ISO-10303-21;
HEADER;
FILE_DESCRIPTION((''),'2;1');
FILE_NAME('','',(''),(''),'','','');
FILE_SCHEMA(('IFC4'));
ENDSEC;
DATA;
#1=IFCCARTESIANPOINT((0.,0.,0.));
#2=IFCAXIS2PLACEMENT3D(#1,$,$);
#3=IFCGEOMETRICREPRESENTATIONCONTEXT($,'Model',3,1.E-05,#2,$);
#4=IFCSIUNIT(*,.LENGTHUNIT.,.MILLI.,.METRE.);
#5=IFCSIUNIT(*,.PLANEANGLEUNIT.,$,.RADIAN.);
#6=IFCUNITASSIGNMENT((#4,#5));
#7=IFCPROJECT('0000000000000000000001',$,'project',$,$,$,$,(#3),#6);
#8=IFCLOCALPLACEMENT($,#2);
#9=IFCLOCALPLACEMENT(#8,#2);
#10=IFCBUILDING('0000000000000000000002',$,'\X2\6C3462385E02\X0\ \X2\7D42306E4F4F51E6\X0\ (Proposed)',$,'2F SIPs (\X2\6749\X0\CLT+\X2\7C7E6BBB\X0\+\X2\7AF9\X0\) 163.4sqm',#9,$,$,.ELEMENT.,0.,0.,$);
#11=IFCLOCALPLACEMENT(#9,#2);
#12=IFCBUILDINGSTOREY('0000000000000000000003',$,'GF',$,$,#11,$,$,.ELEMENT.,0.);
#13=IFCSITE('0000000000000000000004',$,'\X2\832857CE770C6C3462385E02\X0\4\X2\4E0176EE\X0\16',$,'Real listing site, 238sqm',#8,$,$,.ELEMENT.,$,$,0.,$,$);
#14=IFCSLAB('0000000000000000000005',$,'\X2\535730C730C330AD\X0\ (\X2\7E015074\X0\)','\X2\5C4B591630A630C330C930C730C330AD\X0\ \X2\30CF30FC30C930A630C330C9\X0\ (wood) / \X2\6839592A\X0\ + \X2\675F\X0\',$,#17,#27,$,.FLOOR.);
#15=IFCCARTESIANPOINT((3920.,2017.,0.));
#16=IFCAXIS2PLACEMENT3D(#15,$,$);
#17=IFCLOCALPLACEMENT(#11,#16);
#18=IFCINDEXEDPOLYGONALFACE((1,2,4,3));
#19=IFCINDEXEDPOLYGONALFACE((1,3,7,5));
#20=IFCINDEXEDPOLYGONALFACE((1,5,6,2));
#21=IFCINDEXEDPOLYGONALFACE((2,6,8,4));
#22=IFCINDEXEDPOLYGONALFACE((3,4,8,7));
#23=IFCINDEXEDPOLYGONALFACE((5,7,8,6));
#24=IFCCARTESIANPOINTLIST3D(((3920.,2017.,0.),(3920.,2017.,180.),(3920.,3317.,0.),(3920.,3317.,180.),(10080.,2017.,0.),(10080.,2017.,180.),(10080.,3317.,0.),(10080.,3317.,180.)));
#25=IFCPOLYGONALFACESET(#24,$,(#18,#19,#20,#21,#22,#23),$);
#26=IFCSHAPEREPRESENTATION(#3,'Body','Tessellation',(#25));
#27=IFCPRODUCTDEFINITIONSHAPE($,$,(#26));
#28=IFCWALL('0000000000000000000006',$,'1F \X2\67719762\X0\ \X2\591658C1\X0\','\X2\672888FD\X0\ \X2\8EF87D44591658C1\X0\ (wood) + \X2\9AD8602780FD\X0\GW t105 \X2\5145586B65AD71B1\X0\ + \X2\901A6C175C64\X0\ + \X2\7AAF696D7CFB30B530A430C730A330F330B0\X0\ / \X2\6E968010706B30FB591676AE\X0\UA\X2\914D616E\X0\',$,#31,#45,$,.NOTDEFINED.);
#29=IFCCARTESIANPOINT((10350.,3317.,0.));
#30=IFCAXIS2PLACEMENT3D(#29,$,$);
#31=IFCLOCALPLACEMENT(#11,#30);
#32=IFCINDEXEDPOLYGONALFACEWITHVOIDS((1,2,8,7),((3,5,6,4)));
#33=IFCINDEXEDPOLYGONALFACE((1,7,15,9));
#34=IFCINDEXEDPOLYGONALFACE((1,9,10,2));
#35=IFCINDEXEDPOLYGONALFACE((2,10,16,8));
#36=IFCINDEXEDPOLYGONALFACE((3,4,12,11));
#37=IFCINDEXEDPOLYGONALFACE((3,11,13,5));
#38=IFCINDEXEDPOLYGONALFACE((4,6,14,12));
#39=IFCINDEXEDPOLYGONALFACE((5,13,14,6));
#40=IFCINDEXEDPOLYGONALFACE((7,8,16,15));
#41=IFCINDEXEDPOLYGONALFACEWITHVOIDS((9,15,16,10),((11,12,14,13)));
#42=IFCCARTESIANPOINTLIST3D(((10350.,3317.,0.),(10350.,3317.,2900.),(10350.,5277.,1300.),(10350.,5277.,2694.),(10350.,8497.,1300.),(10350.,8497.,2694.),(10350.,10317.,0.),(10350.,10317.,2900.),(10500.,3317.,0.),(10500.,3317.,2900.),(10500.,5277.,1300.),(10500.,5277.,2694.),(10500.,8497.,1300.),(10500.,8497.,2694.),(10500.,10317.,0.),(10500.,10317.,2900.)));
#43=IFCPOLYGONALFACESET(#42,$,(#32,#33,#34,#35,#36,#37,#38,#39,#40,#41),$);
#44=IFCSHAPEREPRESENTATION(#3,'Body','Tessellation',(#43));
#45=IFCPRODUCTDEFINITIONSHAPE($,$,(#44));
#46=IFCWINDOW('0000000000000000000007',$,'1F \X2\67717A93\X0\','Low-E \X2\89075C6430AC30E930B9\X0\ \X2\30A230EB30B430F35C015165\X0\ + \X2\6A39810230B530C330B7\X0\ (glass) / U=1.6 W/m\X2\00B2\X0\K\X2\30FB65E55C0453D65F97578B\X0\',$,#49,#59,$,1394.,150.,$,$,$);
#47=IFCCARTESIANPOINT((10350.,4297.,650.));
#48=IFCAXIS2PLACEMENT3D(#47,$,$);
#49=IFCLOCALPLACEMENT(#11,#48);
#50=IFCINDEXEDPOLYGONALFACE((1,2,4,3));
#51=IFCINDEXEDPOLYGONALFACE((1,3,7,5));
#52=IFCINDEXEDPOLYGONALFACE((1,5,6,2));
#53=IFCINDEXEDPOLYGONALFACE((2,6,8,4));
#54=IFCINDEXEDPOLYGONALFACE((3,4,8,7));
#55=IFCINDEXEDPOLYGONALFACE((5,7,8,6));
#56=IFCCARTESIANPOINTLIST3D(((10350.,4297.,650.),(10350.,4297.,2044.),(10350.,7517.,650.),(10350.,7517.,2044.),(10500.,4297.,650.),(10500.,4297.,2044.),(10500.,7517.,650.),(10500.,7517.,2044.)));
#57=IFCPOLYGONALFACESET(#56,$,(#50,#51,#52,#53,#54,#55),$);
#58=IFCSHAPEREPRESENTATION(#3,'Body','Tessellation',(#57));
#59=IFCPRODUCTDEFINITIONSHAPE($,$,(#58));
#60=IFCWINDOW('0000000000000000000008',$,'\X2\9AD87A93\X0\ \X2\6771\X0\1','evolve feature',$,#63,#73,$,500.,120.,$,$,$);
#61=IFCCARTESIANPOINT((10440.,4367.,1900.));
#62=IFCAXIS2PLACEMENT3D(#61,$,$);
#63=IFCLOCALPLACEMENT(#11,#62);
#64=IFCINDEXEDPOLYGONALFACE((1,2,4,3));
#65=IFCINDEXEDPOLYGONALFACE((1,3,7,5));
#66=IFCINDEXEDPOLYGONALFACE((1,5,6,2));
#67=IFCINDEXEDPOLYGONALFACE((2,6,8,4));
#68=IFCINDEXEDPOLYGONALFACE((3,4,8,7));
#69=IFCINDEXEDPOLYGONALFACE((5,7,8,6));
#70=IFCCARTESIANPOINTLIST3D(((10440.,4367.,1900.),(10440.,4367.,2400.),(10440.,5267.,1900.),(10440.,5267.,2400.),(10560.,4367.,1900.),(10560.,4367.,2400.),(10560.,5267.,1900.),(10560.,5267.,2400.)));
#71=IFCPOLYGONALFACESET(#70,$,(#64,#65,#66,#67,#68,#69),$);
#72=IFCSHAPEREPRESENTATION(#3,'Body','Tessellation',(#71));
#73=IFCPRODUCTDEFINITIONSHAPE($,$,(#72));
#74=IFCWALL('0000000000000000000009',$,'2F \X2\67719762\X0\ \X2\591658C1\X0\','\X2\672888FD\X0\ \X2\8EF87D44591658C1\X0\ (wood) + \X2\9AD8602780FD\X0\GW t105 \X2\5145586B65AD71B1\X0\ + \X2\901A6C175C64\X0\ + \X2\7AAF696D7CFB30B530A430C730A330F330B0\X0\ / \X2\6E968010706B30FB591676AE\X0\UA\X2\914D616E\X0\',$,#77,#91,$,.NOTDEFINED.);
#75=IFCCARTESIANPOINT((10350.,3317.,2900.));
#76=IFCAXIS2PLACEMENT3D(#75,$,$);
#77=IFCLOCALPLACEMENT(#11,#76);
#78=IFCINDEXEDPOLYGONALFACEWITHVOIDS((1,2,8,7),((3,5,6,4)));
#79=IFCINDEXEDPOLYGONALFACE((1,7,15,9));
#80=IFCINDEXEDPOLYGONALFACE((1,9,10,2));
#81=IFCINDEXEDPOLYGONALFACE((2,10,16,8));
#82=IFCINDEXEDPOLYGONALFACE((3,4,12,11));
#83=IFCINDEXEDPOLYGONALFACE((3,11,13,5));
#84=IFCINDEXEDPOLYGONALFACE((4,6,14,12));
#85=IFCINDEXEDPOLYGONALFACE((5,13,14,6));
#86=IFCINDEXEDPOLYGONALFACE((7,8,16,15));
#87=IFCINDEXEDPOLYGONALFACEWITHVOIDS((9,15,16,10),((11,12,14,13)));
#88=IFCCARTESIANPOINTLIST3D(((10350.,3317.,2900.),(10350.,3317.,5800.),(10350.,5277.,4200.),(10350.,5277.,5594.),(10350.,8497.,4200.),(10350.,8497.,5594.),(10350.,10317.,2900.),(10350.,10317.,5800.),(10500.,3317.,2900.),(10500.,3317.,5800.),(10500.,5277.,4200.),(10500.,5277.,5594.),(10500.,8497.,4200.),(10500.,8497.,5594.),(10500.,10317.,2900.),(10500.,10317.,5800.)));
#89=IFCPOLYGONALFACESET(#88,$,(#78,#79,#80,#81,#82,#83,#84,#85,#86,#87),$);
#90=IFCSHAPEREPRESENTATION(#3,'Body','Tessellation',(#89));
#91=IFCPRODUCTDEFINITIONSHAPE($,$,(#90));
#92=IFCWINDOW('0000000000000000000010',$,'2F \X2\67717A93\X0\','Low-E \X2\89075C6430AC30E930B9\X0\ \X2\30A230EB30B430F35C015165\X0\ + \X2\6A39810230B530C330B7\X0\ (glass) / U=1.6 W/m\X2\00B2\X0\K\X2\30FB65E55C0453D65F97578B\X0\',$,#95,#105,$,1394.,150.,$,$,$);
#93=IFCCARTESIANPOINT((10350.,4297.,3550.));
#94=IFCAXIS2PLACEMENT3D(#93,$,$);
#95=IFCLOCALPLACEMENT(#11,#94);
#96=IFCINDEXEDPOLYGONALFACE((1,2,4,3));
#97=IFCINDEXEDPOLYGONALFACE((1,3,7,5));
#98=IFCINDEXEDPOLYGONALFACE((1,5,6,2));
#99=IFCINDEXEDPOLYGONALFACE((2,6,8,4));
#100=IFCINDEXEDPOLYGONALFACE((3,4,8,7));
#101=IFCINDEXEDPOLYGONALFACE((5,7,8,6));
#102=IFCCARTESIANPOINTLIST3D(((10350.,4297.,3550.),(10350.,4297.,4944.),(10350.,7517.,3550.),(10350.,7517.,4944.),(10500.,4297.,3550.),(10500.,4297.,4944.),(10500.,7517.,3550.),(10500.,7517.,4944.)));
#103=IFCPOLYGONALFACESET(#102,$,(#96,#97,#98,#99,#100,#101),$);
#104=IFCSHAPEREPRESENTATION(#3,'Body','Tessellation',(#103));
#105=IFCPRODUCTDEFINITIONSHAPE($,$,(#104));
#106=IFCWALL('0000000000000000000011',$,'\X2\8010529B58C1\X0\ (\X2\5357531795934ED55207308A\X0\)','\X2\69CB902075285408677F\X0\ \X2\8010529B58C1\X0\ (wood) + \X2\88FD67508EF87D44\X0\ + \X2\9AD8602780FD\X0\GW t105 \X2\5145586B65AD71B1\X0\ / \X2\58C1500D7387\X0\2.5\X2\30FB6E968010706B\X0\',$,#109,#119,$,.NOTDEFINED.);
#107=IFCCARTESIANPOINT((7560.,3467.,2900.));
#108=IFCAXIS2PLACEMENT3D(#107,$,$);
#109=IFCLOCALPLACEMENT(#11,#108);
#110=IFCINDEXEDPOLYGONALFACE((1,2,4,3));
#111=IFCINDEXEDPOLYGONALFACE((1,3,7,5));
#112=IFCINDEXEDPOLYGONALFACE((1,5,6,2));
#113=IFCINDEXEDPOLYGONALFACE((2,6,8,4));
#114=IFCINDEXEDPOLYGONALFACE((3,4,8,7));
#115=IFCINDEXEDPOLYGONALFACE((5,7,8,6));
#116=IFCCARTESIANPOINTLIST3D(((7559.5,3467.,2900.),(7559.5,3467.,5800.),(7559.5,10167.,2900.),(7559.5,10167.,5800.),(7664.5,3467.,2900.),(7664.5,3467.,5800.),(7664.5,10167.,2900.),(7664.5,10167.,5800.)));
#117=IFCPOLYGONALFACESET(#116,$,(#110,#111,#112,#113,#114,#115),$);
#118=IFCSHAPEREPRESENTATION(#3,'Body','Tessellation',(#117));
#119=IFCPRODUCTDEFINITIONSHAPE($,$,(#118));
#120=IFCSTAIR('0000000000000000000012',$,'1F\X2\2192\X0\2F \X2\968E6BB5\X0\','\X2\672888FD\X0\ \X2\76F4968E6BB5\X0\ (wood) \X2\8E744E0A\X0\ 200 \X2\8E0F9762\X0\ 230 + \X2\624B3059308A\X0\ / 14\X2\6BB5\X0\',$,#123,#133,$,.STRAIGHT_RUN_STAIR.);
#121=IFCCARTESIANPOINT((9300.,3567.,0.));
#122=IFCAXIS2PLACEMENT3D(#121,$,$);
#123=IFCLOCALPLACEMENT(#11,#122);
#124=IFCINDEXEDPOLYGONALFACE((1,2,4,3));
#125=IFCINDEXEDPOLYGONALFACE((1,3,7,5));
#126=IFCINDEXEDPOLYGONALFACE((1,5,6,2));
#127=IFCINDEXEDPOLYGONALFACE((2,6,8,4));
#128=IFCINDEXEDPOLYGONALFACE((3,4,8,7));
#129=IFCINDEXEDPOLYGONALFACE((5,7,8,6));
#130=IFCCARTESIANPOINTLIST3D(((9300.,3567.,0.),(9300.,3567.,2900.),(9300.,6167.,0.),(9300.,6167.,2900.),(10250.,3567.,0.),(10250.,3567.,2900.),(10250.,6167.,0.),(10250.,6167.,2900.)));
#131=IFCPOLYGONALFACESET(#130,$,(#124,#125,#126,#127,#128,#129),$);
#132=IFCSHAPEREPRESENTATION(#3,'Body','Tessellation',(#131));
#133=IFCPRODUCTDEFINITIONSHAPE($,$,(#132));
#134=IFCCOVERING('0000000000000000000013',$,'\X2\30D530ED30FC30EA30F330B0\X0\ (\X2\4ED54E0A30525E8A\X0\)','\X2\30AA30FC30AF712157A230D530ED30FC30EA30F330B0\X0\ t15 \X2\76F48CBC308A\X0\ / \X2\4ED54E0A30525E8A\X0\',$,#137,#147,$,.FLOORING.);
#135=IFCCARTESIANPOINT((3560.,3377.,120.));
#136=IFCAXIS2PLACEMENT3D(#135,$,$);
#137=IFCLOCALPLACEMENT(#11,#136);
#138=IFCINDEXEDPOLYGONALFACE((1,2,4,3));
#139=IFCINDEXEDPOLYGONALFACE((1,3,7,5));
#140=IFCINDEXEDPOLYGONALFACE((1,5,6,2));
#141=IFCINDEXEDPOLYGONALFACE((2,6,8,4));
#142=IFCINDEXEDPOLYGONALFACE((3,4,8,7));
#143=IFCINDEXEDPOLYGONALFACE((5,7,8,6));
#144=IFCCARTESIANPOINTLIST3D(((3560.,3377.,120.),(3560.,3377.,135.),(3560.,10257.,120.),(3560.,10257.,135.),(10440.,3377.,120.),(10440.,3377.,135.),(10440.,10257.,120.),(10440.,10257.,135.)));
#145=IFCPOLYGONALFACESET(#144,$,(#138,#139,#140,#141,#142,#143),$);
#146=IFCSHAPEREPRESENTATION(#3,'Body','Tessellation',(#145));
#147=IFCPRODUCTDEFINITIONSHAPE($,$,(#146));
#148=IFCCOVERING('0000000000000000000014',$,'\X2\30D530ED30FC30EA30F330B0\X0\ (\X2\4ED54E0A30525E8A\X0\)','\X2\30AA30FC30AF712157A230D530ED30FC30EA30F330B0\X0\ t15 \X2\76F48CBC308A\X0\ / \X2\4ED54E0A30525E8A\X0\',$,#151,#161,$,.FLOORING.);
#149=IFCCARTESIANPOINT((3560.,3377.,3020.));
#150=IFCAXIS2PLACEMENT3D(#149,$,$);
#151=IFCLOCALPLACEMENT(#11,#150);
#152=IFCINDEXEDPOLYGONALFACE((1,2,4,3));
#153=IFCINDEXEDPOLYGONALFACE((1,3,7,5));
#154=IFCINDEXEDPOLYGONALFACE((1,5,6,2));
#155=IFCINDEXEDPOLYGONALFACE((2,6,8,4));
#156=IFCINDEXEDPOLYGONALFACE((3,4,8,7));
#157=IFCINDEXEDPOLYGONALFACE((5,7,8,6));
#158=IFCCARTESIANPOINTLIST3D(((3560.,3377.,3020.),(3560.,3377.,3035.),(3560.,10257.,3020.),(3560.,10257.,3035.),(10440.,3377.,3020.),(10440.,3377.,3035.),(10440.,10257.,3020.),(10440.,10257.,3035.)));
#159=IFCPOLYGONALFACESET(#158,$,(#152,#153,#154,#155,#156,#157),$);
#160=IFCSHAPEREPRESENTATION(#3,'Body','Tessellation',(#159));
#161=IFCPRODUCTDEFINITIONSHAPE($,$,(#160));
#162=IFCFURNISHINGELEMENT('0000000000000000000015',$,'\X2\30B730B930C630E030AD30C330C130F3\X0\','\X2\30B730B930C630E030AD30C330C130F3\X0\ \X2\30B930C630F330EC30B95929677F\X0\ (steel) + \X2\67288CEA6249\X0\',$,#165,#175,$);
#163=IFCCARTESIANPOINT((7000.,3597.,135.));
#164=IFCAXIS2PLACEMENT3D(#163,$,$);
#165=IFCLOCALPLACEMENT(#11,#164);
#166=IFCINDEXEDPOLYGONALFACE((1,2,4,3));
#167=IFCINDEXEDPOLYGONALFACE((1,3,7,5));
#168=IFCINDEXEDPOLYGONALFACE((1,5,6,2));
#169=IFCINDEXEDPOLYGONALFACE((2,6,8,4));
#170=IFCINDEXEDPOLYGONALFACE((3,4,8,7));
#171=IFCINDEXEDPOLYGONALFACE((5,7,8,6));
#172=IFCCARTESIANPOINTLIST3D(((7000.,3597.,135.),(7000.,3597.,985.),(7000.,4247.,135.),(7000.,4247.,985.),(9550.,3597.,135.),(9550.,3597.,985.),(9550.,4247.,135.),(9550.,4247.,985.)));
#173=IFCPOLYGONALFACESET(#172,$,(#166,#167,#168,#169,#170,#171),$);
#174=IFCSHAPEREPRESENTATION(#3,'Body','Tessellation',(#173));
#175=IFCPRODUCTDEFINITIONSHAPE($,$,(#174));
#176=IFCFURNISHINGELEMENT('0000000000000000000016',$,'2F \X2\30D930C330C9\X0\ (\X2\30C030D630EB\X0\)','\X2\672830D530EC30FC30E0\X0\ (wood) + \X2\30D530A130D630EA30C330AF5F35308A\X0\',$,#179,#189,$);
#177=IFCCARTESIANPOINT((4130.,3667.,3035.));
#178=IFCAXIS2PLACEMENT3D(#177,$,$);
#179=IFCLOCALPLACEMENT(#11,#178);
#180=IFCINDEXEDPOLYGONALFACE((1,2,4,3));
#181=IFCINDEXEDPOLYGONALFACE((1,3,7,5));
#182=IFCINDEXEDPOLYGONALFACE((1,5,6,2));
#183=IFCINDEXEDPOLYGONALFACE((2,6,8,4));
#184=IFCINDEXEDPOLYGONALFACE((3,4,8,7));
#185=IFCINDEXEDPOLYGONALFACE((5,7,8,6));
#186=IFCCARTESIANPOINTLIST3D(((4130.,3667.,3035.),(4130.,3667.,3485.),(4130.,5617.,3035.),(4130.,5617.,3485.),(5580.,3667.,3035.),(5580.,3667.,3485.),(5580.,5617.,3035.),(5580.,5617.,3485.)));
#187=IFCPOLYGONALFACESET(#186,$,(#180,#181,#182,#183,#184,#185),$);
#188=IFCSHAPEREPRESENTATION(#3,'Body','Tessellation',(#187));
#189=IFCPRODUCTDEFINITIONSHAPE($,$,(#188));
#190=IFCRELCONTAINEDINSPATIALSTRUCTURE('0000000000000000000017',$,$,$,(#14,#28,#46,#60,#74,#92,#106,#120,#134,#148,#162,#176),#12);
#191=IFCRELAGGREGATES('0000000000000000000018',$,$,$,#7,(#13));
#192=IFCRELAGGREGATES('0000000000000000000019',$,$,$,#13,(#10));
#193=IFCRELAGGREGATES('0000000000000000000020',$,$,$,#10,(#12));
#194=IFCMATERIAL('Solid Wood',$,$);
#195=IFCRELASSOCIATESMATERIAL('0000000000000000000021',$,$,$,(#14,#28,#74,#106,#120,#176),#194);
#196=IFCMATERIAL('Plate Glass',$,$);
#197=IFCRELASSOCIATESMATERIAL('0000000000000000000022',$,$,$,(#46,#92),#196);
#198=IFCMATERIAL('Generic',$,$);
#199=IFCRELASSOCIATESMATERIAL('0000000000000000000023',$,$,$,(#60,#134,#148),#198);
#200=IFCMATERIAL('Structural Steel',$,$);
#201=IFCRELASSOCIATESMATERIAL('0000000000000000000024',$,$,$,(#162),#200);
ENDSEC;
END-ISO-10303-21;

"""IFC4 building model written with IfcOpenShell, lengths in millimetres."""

from ifc_helpers import new_model, si_unit, frame, frame_2d, origin, place, context, project, spatial, rectangle, extrude, material, element, fill, save


model = new_model("IFC4")

# Units and contexts
model_context = context("Model", 3, precision=1e-05, world=origin())
ifc_project = project(units=[si_unit("LENGTHUNIT", "METRE", prefix="MILLI"), si_unit("PLANEANGLEUNIT", "RADIAN")], contexts=[model_context])

# Site, building, storey
site_placement = place(None, origin())
site = spatial("IfcSite", under=ifc_project, at=site_placement, Name="茨城県水戸市4丁目16", ObjectType="Real listing site, 238sqm", CompositionType="ELEMENT", RefElevation=0.0)
building_placement = place(site_placement, origin())
building = spatial("IfcBuilding", under=site, at=building_placement, Name="水戸市 終の住処 (Proposed)", ObjectType="2F SIPs (杉CLT+籾殻+竹) 163.4sqm", CompositionType="ELEMENT", ElevationOfRefHeight=0.0, ElevationOfTerrain=0.0)
storey_placement = place(building_placement, origin())
storey = spatial("IfcBuildingStorey", under=building, at=storey_placement, Name="GF", CompositionType="ELEMENT", Elevation=0.0)

# Slab
ifc_material_1 = material(Name="Solid Wood")
slab_placement = place(storey_placement, frame((3920.0, 2017.0, 0.0)))
element("IfcSlab", 1, at=slab_placement, inside=storey, material=ifc_material_1, Name="南デッキ (縁側)", Description="屋外ウッドデッキ ハードウッド (wood) / 根太 + 束", PredefinedType="FLOOR", context=model_context, shape_type="SweptSolid", body=[
    extrude(rectangle(XDim=6160.0, YDim=1300.0, at=frame_2d((3080.0, 650.0))), frame((3920.0, 2017.0, 0.0)), (0.0, 0.0, 1.0), 180.0),
])

# Wall, openings, windows
wall_1_placement = place(storey_placement, frame((10350.0, 3317.0, 0.0)))
wall_1 = element("IfcWall", 2, at=wall_1_placement, inside=storey, material=ifc_material_1, Name="1F 東面 外壁", Description="木製 軸組外壁 (wood) + 高性能GW t105 充填断熱 + 通気層 + 窯業系サイディング / 準耐火・外皮UA配慮", PredefinedType="NOTDEFINED", context=model_context, shape_type="SweptSolid", body=[
    extrude(rectangle(XDim=150.0, YDim=7000.0, at=frame_2d((75.0, 3500.0))), frame((10350.0, 3317.0, 0.0)), (0.0, 0.0, 1.0), 2900.0),
])
opening_1_placement = place(storey_placement, frame((10350.0, 4297.0, 650.0)))
opening_1 = element("IfcOpeningElement", 3, at=opening_1_placement, cuts=wall_1, PredefinedType="NOTDEFINED", context=model_context, shape_type="SweptSolid", body=[
    extrude(rectangle(XDim=150.0, YDim=3220.0, at=frame_2d((75.0, 1610.0))), frame((10350.0, 4297.0, 650.0)), (0.0, 0.0, 1.0), 1394.0),
])
opening_2_placement = place(storey_placement, frame((10440.0, 4367.0, 1900.0)))
opening_2 = element("IfcOpeningElement", 4, at=opening_2_placement, cuts=wall_1, PredefinedType="NOTDEFINED", context=model_context, shape_type="SweptSolid", body=[
    extrude(rectangle(XDim=120.0, YDim=900.0, at=frame_2d((60.0, 450.0))), frame((10440.0, 4367.0, 1900.0)), (0.0, 0.0, 1.0), 500.0),
])
ifc_material_2 = material(Name="Plate Glass")
window_1_placement = place(storey_placement, frame((10350.0, 4297.0, 650.0)))
window_1 = element("IfcWindow", 5, at=window_1_placement, inside=storey, material=ifc_material_2, Name="1F 東窓", Description="Low-E 複層ガラス アルゴン封入 + 樹脂サッシ (glass) / U=1.6 W/m²K・日射取得型", OverallHeight=1394.0, OverallWidth=150.0, context=model_context, shape_type="SweptSolid", body=[
    extrude(rectangle(XDim=150.0, YDim=3220.0, at=frame_2d((75.0, 1610.0))), frame((10350.0, 4297.0, 650.0)), (0.0, 0.0, 1.0), 1394.0),
])
fill(opening_1, window_1)
ifc_material_3 = material(Name="Generic")
window_2_placement = place(storey_placement, frame((10440.0, 4367.0, 1900.0)))
window_2 = element("IfcWindow", 6, at=window_2_placement, inside=storey, material=ifc_material_3, Name="高窓 東1", Description="evolve feature", OverallHeight=500.0, OverallWidth=120.0, context=model_context, shape_type="SweptSolid", body=[
    extrude(rectangle(XDim=120.0, YDim=900.0, at=frame_2d((60.0, 450.0))), frame((10440.0, 4367.0, 1900.0)), (0.0, 0.0, 1.0), 500.0),
])
fill(opening_2, window_2)

# Wall, opening, window
wall_2_placement = place(storey_placement, frame((10350.0, 3317.0, 2900.0)))
wall_2 = element("IfcWall", 7, at=wall_2_placement, inside=storey, material=ifc_material_1, Name="2F 東面 外壁", Description="木製 軸組外壁 (wood) + 高性能GW t105 充填断熱 + 通気層 + 窯業系サイディング / 準耐火・外皮UA配慮", PredefinedType="NOTDEFINED", context=model_context, shape_type="SweptSolid", body=[
    extrude(rectangle(XDim=150.0, YDim=7000.0, at=frame_2d((75.0, 3500.0))), frame((10350.0, 3317.0, 2900.0)), (0.0, 0.0, 1.0), 2900.0),
])
opening_3_placement = place(storey_placement, frame((10350.0, 4297.0, 3550.0)))
opening_3 = element("IfcOpeningElement", 8, at=opening_3_placement, cuts=wall_2, PredefinedType="NOTDEFINED", context=model_context, shape_type="SweptSolid", body=[
    extrude(rectangle(XDim=150.0, YDim=3220.0, at=frame_2d((75.0, 1610.0))), frame((10350.0, 4297.0, 3550.0)), (0.0, 0.0, 1.0), 1394.0),
])
window_3_placement = place(storey_placement, frame((10350.0, 4297.0, 3550.0)))
window_3 = element("IfcWindow", 9, at=window_3_placement, inside=storey, material=ifc_material_2, Name="2F 東窓", Description="Low-E 複層ガラス アルゴン封入 + 樹脂サッシ (glass) / U=1.6 W/m²K・日射取得型", OverallHeight=1394.0, OverallWidth=150.0, context=model_context, shape_type="SweptSolid", body=[
    extrude(rectangle(XDim=150.0, YDim=3220.0, at=frame_2d((75.0, 1610.0))), frame((10350.0, 4297.0, 3550.0)), (0.0, 0.0, 1.0), 1394.0),
])
fill(opening_3, window_3)

# Wall
wall_3_placement = place(storey_placement, frame((7560.0, 3467.0, 2900.0)))
element("IfcWall", 10, at=wall_3_placement, inside=storey, material=ifc_material_1, Name="耐力壁 (南北間仕切り)", Description="構造用合板 耐力壁 (wood) + 製材軸組 + 高性能GW t105 充填断熱 / 壁倍率2.5・準耐火", PredefinedType="NOTDEFINED", context=model_context, shape_type="SweptSolid", body=[
    extrude(rectangle(XDim=105.0, YDim=6700.0, at=frame_2d((52.0, 3350.0))), frame((7560.0, 3467.0, 2900.0)), (0.0, 0.0, 1.0), 2900.0),
])

# Stair
stair_placement = place(storey_placement, frame((9300.0, 3567.0, 0.0)))
element("IfcStair", 11, at=stair_placement, inside=storey, material=ifc_material_1, Name="1F→2F 階段", Description="木製 直階段 (wood) 蹴上 200 踏面 230 + 手すり / 14段", PredefinedType="STRAIGHT_RUN_STAIR", context=model_context, shape_type="SweptSolid", body=[
    extrude(rectangle(XDim=950.0, YDim=2600.0, at=frame_2d((475.0, 1300.0))), frame((9300.0, 3567.0, 0.0)), (0.0, 0.0, 1.0), 2900.0),
])

# Coverings
covering_1_placement = place(storey_placement, frame((3560.0, 3377.0, 120.0)))
element("IfcCovering", 12, at=covering_1_placement, inside=storey, material=ifc_material_3, Name="フローリング (仕上げ床)", Description="オーク無垢フローリング t15 直貼り / 仕上げ床", PredefinedType="FLOORING", context=model_context, shape_type="SweptSolid", body=[
    extrude(rectangle(XDim=6880.0, YDim=6880.0, at=frame_2d((3440.0, 3440.0))), frame((3560.0, 3377.0, 120.0)), (0.0, 0.0, 1.0), 15.0),
])
covering_2_placement = place(storey_placement, frame((3560.0, 3377.0, 3020.0)))
element("IfcCovering", 13, at=covering_2_placement, inside=storey, material=ifc_material_3, Name="フローリング (仕上げ床)", Description="オーク無垢フローリング t15 直貼り / 仕上げ床", PredefinedType="FLOORING", context=model_context, shape_type="SweptSolid", body=[
    extrude(rectangle(XDim=6880.0, YDim=6880.0, at=frame_2d((3440.0, 3440.0))), frame((3560.0, 3377.0, 3020.0)), (0.0, 0.0, 1.0), 15.0),
])

# Furnishing elements
ifc_material_4 = material(Name="Structural Steel")
furnishing_1_placement = place(storey_placement, frame((7000.0, 3597.0, 135.0)))
element("IfcFurnishingElement", 14, at=furnishing_1_placement, inside=storey, material=ifc_material_4, Name="システムキッチン", Description="システムキッチン ステンレス天板 (steel) + 木質扉", context=model_context, shape_type="SweptSolid", body=[
    extrude(rectangle(XDim=2550.0, YDim=650.0, at=frame_2d((1275.0, 325.0))), frame((7000.0, 3597.0, 135.0)), (0.0, 0.0, 1.0), 850.0),
])
furnishing_2_placement = place(storey_placement, frame((4130.0, 3667.0, 3035.0)))
element("IfcFurnishingElement", 15, at=furnishing_2_placement, inside=storey, material=ifc_material_1, Name="2F ベッド (ダブル)", Description="木フレーム (wood) + ファブリック張り", context=model_context, shape_type="SweptSolid", body=[
    extrude(rectangle(XDim=1450.0, YDim=1950.0, at=frame_2d((725.0, 975.0))), frame((4130.0, 3667.0, 3035.0)), (0.0, 0.0, 1.0), 450.0),
])

save(model, "model.ifc")
